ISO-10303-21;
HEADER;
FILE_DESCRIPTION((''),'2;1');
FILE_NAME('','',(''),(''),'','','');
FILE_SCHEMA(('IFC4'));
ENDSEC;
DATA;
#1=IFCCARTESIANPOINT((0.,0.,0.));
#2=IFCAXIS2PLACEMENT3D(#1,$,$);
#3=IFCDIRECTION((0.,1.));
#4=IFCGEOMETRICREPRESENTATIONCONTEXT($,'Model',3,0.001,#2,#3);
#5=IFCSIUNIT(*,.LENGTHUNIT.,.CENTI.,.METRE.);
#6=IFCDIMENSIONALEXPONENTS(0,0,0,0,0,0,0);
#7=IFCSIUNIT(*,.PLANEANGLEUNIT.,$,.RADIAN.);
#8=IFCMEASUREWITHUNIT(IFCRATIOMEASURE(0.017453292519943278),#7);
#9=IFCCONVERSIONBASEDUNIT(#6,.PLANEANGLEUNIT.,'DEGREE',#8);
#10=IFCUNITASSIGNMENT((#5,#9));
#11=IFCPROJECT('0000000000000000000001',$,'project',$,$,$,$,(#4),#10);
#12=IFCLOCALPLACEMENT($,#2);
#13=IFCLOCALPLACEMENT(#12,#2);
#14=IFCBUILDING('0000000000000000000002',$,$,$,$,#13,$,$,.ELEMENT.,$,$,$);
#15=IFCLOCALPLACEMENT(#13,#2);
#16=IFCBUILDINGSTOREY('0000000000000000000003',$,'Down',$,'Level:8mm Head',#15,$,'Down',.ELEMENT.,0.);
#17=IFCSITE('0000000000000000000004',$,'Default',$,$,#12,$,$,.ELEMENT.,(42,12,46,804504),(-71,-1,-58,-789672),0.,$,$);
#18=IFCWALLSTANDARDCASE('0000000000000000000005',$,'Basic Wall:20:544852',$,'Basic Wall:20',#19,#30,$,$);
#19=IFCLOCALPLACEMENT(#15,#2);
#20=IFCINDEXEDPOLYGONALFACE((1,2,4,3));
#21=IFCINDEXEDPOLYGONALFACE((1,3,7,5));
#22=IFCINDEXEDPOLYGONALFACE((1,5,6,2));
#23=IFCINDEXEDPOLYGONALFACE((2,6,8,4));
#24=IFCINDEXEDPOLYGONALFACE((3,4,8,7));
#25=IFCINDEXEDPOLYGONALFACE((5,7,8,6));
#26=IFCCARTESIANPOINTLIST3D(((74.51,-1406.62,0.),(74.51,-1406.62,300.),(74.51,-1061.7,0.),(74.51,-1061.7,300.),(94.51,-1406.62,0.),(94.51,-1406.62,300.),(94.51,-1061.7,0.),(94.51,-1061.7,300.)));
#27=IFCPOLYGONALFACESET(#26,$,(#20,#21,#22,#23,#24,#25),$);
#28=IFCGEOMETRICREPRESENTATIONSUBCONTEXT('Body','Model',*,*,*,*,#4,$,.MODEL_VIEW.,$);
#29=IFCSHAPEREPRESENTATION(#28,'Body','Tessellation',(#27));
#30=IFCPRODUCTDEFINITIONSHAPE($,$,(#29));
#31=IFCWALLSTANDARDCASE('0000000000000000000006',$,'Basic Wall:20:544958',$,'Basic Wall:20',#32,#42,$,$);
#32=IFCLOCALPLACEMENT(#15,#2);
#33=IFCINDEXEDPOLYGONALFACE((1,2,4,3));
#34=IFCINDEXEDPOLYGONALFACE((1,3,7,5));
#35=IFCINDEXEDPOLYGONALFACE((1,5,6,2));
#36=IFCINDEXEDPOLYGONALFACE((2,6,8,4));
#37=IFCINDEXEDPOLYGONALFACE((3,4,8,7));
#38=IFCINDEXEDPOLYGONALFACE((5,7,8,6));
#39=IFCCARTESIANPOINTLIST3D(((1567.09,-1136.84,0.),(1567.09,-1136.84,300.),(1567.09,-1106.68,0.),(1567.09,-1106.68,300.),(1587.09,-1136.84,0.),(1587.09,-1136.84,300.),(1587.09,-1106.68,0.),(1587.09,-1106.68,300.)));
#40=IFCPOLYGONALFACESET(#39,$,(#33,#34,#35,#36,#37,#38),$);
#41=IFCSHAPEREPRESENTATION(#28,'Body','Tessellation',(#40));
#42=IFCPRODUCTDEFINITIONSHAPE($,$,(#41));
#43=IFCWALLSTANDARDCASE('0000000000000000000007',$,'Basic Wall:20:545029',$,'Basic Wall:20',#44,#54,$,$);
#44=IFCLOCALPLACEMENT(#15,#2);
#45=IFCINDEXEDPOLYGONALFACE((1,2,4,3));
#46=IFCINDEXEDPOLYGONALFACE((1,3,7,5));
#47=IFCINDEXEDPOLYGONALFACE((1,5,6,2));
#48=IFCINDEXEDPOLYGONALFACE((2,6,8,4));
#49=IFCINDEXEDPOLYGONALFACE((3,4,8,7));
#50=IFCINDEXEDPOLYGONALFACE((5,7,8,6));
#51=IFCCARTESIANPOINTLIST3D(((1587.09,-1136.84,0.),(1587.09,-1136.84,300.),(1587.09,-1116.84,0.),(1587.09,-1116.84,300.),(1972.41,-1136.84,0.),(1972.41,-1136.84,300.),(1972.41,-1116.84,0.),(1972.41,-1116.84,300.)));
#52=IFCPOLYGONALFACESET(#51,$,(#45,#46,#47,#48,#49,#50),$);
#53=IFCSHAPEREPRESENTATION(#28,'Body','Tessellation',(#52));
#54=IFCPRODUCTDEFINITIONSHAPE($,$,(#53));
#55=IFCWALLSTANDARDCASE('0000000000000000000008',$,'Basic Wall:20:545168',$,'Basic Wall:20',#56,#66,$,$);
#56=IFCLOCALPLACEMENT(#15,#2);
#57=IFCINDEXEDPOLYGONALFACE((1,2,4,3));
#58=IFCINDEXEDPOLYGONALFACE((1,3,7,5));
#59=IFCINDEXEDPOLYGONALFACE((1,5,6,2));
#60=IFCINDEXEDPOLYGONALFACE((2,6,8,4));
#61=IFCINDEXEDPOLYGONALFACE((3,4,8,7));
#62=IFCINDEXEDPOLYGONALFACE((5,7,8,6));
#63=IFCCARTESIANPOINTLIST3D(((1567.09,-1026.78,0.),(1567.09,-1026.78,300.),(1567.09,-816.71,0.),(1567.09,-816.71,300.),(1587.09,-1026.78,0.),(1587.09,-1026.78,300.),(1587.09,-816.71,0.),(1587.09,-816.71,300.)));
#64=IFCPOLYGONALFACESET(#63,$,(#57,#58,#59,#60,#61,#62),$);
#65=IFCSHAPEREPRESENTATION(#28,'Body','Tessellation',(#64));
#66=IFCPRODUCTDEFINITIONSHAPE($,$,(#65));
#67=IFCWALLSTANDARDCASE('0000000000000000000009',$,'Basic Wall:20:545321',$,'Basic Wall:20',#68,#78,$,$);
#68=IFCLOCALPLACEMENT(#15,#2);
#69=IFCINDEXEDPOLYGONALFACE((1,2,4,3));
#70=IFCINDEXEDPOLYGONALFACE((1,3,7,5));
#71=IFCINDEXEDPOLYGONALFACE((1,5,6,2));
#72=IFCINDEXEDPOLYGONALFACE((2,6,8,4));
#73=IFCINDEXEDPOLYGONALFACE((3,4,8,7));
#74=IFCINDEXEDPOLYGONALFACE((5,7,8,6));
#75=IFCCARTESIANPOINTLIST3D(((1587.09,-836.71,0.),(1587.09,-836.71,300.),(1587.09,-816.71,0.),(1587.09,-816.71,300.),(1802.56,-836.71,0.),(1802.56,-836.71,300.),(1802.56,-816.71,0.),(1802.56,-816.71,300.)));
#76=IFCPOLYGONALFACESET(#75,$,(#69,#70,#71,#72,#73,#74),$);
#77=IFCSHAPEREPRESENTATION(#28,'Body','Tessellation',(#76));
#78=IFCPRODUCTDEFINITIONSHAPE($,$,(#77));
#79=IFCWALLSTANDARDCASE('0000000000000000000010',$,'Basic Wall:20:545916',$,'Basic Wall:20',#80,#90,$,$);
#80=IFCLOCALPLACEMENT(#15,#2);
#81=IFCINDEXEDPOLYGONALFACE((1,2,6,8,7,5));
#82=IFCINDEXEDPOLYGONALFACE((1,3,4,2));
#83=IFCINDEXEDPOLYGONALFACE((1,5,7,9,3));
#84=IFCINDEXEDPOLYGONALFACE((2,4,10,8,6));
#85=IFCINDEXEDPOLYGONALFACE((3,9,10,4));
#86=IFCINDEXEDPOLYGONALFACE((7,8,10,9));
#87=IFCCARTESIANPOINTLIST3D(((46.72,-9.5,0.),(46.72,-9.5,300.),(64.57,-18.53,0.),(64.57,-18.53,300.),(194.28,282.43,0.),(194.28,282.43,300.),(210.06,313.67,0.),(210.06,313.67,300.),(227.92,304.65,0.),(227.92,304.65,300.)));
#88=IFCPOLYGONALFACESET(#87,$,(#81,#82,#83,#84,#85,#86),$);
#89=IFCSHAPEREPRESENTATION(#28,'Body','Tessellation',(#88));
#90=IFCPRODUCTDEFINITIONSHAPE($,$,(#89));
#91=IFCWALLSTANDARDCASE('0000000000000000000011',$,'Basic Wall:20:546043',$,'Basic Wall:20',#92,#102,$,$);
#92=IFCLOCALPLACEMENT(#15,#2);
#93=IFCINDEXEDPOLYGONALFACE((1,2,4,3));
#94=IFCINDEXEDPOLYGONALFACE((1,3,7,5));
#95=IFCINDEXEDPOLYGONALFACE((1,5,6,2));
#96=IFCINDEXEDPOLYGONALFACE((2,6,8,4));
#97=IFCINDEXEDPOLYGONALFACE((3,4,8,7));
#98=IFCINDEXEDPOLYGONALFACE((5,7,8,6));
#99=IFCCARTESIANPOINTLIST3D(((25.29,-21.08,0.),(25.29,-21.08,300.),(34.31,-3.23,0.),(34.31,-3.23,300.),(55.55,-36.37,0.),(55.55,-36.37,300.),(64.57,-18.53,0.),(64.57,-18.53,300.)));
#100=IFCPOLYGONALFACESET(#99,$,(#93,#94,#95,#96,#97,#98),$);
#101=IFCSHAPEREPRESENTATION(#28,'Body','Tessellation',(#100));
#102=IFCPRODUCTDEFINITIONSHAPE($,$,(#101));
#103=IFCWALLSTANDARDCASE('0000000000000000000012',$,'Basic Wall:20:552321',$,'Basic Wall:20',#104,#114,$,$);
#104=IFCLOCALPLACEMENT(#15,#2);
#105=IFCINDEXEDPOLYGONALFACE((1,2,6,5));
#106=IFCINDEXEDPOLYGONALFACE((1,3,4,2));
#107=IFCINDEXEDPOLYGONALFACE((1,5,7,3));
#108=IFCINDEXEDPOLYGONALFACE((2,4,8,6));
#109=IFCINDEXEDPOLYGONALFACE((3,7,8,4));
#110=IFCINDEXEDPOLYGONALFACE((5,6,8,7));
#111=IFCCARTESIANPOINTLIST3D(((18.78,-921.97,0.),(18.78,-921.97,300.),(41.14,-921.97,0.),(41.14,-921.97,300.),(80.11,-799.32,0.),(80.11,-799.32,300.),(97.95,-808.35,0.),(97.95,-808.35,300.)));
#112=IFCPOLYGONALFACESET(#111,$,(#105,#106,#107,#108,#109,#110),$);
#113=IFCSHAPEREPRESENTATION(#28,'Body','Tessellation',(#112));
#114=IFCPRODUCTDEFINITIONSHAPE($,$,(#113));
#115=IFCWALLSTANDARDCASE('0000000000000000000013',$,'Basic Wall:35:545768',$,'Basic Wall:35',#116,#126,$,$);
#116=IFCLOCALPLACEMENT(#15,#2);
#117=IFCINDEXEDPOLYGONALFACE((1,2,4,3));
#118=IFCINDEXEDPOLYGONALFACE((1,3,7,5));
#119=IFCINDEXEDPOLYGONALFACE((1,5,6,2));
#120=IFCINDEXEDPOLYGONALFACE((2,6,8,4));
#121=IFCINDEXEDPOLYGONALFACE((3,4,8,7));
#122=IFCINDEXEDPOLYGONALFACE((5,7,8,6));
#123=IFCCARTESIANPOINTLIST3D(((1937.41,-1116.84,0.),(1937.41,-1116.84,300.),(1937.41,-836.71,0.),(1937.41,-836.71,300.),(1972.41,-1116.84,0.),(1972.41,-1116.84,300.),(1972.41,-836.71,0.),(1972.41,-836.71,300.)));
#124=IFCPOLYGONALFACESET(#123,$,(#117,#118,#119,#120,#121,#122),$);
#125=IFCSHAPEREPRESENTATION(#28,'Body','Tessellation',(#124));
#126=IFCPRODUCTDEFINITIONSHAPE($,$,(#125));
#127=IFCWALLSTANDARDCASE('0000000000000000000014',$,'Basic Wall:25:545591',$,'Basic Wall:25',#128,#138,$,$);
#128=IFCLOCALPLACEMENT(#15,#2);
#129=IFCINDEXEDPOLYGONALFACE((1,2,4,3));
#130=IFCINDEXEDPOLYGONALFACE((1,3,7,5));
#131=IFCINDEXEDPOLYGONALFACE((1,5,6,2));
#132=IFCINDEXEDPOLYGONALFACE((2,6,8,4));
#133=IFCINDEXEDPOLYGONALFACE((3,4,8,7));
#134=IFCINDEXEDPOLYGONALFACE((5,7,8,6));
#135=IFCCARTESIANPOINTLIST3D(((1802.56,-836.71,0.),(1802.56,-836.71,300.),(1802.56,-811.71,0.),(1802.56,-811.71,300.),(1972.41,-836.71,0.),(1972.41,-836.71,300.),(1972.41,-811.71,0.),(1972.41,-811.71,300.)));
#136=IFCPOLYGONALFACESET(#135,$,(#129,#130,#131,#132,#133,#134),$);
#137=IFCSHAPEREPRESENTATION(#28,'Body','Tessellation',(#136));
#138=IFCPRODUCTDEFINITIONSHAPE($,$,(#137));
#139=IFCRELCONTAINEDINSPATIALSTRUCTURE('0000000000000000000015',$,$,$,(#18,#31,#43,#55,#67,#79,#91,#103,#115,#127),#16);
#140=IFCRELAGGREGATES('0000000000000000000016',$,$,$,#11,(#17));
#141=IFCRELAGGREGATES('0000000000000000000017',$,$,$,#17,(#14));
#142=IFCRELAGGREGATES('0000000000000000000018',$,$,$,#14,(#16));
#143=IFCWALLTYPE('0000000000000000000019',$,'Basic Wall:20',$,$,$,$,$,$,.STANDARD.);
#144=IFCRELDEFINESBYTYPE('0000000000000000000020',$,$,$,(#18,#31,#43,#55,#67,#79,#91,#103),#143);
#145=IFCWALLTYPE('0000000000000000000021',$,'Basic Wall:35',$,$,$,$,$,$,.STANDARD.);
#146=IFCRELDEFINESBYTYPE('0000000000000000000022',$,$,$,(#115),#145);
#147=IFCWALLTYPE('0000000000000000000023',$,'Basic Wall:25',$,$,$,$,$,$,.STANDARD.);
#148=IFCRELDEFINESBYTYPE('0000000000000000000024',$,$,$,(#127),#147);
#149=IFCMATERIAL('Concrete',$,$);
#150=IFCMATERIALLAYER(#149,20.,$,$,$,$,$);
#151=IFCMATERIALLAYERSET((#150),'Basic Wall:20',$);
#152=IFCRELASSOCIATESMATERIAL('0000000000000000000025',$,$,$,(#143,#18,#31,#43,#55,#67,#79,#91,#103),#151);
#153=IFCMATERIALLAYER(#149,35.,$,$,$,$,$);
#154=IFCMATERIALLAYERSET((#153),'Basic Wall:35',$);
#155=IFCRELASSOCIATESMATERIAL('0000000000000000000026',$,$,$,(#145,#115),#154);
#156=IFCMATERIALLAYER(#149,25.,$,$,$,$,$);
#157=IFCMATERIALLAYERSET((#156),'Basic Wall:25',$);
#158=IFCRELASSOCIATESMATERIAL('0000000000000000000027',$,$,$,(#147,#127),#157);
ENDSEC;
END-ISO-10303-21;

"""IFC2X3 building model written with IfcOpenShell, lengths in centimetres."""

from ifc_helpers import new_model, entity, si_unit, converted_unit, direction, frame, frame_2d, origin, place, context, subcontext, project, spatial, polyline, rectangle, outline, extrude, material, layer, layer_set, layer_usage, type_object, element, save


model = new_model("IFC2X3")

# Units and contexts
model_context = context("Model", 3, precision=0.001, world=origin(), true_north=direction((0.0, 1.0)))
body_context = subcontext(model_context, "Body", "Model", "MODEL_VIEW")
ifc_project = project(units=[si_unit("LENGTHUNIT", "METRE", prefix="CENTI"), converted_unit("PLANEANGLEUNIT", "DEGREE", entity("IfcRatioMeasure", 0.017453292519943278), si_unit("PLANEANGLEUNIT", "RADIAN"), dimensions=[0, 0, 0, 0, 0, 0, 0])], contexts=[model_context])

# Site, building, storey
site_placement = place(None, origin())
site = spatial("IfcSite", under=ifc_project, at=site_placement, Name="Default", CompositionType="ELEMENT", RefLatitude=(42, 12, 46, 804504), RefLongitude=(-71, -1, -58, -789672), RefElevation=0.0)
building_placement = place(site_placement, origin())
building = spatial("IfcBuilding", under=site, at=building_placement, CompositionType="ELEMENT")
storey_placement = place(building_placement, origin())
storey = spatial("IfcBuildingStorey", under=building, at=storey_placement, Name="Down", ObjectType="Level:8mm Head", LongName="Down", CompositionType="ELEMENT", Elevation=0.0)

# Shared definitions
ifc_material = material(Name="Concrete")

# Walls
ifc_layer_1 = layer(ifc_material, 20.0)
ifc_layer_set_1 = layer_set([ifc_layer_1], Name="Basic Wall:20")
wall_type_1 = type_object("IfcWallType", Name="Basic Wall:20", PredefinedType="STANDARD", material=ifc_layer_set_1)
ifc_layer_usage_1 = layer_usage(ifc_layer_set_1, "AXIS2", "POSITIVE", -10.0)
wall_1_placement = place(storey_placement, frame((84.51, -1406.62, 0.0), z_axis=(0.0, 0.0, 1.0), x_axis=(0.0, 1.0, 0.0)))
element("IfcWallStandardCase", 1, at=wall_1_placement, inside=storey, type_object=wall_type_1, material=ifc_layer_usage_1, Name="Basic Wall:20:544852", ObjectType="Basic Wall:20", context=body_context, shape_type="SweptSolid", body=[
    extrude(rectangle(XDim=344.92, YDim=20.0, at=frame_2d((172.46, 0.0), x_axis=(-1.0, 0.0))), origin(), (0.0, 0.0, 1.0), 300.0),
])
ifc_layer_usage_2 = layer_usage(ifc_layer_set_1, "AXIS2", "POSITIVE", -10.0)
wall_2_placement = place(storey_placement, frame((1577.09, -1106.68, 0.0), z_axis=(0.0, 0.0, 1.0), x_axis=(0.0, -1.0, 0.0)))
element("IfcWallStandardCase", 2, at=wall_2_placement, inside=storey, type_object=wall_type_1, material=ifc_layer_usage_2, Name="Basic Wall:20:544958", ObjectType="Basic Wall:20", context=body_context, shape_type="SweptSolid", body=[
    extrude(rectangle(XDim=30.16, YDim=20.0, at=frame_2d((15.08, 0.0), x_axis=(-1.0, 0.0))), origin(), (0.0, 0.0, 1.0), 300.0),
])
ifc_layer_usage_3 = layer_usage(ifc_layer_set_1, "AXIS2", "POSITIVE", -10.0)
wall_3_placement = place(storey_placement, frame((1587.09, -1126.84, 0.0)))
element("IfcWallStandardCase", 3, at=wall_3_placement, inside=storey, type_object=wall_type_1, material=ifc_layer_usage_3, Name="Basic Wall:20:545029", ObjectType="Basic Wall:20", context=body_context, shape_type="SweptSolid", body=[
    extrude(rectangle(XDim=385.32, YDim=20.0, at=frame_2d((192.66, 0.0), x_axis=(-1.0, 0.0))), origin(), (0.0, 0.0, 1.0), 300.0),
])
ifc_layer_usage_4 = layer_usage(ifc_layer_set_1, "AXIS2", "NEGATIVE", 10.0)
wall_4_placement = place(storey_placement, frame((1577.09, -1026.78, 0.0), z_axis=(0.0, 0.0, 1.0), x_axis=(0.0, 1.0, 0.0)))
element("IfcWallStandardCase", 4, at=wall_4_placement, inside=storey, type_object=wall_type_1, material=ifc_layer_usage_4, Name="Basic Wall:20:545168", ObjectType="Basic Wall:20", context=body_context, shape_type="SweptSolid", body=[
    extrude(rectangle(XDim=210.07, YDim=20.0, at=frame_2d((105.03, 0.0), x_axis=(-1.0, 0.0))), origin(), (0.0, 0.0, 1.0), 300.0),
])
ifc_layer_usage_5 = layer_usage(ifc_layer_set_1, "AXIS2", "NEGATIVE", 10.0)
wall_5_placement = place(storey_placement, frame((1587.09, -826.71, 0.0)))
element("IfcWallStandardCase", 5, at=wall_5_placement, inside=storey, type_object=wall_type_1, material=ifc_layer_usage_5, Name="Basic Wall:20:545321", ObjectType="Basic Wall:20", context=body_context, shape_type="SweptSolid", body=[
    extrude(rectangle(XDim=215.47, YDim=20.0, at=frame_2d((107.73, 0.0), x_axis=(-1.0, 0.0))), origin(), (0.0, 0.0, 1.0), 300.0),
])
ifc_layer_usage_6 = layer_usage(ifc_layer_set_1, "AXIS2", "NEGATIVE", 10.0)
wall_6_placement = place(storey_placement, frame((218.99, 309.16, 0.0), z_axis=(0.0, 0.0, 1.0), x_axis=(-0.451084, -0.892482, 0.0)))
element("IfcWallStandardCase", 6, at=wall_6_placement, inside=storey, type_object=wall_type_1, material=ifc_layer_usage_6, Name="Basic Wall:20:545916", ObjectType="Basic Wall:20", context=body_context, shape_type="SweptSolid", body=[
    extrude(outline(polyline([(362.11, -10.0), (362.11, 10.0), (0.0, 10.0), (0.0, -10.0), (35.0, -10.0), (362.11, -10.0)])), origin(), (0.0, 0.0, 1.0), 300.0),
])
ifc_layer_usage_7 = layer_usage(ifc_layer_set_1, "AXIS2", "NEGATIVE", 10.0)
wall_7_placement = place(storey_placement, frame((60.06, -27.45, 0.0), z_axis=(0.0, 0.0, 1.0), x_axis=(-0.892482, 0.451084, 0.0)))
element("IfcWallStandardCase", 7, at=wall_7_placement, inside=storey, type_object=wall_type_1, material=ifc_layer_usage_7, Name="Basic Wall:20:546043", ObjectType="Basic Wall:20", context=body_context, shape_type="SweptSolid", body=[
    extrude(rectangle(XDim=33.91, YDim=20.0, at=frame_2d((16.96, 0.0), x_axis=(-1.0, 0.0))), origin(), (0.0, 0.0, 1.0), 300.0),
])
ifc_layer_usage_8 = layer_usage(ifc_layer_set_1, "AXIS2", "POSITIVE", -10.0)
wall_8_placement = place(storey_placement, frame((27.73, -926.44, 0.0), z_axis=(0.0, 0.0, 1.0), x_axis=(0.447214, 0.894427, 0.0)))
element("IfcWallStandardCase", 8, at=wall_8_placement, inside=storey, type_object=wall_type_1, material=ifc_layer_usage_8, Name="Basic Wall:20:552321", ObjectType="Basic Wall:20", context=body_context, shape_type="SweptSolid", body=[
    extrude(outline(polyline([(137.04, -10.0), (137.13, 10.0), (0.0, 10.0), (10.0, -10.0), (137.04, -10.0)])), origin(), (0.0, 0.0, 1.0), 300.0),
])
ifc_layer_2 = layer(ifc_material, 35.0)
ifc_layer_set_2 = layer_set([ifc_layer_2], Name="Basic Wall:35")
ifc_layer_usage_9 = layer_usage(ifc_layer_set_2, "AXIS2", "NEGATIVE", 17.5)
wall_type_2 = type_object("IfcWallType", Name="Basic Wall:35", PredefinedType="STANDARD", material=ifc_layer_set_2)
wall_9_placement = place(storey_placement, frame((1954.91, -836.71, 0.0), z_axis=(0.0, 0.0, 1.0), x_axis=(0.0, -1.0, 0.0)))
element("IfcWallStandardCase", 9, at=wall_9_placement, inside=storey, type_object=wall_type_2, material=ifc_layer_usage_9, Name="Basic Wall:35:545768", ObjectType="Basic Wall:35", context=body_context, shape_type="SweptSolid", body=[
    extrude(rectangle(XDim=280.13, YDim=35.0, at=frame_2d((140.06, 0.0), x_axis=(-1.0, 0.0))), origin(), (0.0, 0.0, 1.0), 300.0),
])
ifc_layer_3 = layer(ifc_material, 25.0)
ifc_layer_set_3 = layer_set([ifc_layer_3], Name="Basic Wall:25")
ifc_layer_usage_10 = layer_usage(ifc_layer_set_3, "AXIS2", "POSITIVE", -12.5)
wall_type_3 = type_object("IfcWallType", Name="Basic Wall:25", PredefinedType="STANDARD", material=ifc_layer_set_3)
wall_10_placement = place(storey_placement, frame((1802.56, -824.21, 0.0)))
element("IfcWallStandardCase", 10, at=wall_10_placement, inside=storey, type_object=wall_type_3, material=ifc_layer_usage_10, Name="Basic Wall:25:545591", ObjectType="Basic Wall:25", context=body_context, shape_type="SweptSolid", body=[
    extrude(rectangle(XDim=169.85, YDim=25.0, at=frame_2d((84.93, 0.0), x_axis=(-1.0, 0.0))), origin(), (0.0, 0.0, 1.0), 300.0),
])

save(model, "model.ifc")
